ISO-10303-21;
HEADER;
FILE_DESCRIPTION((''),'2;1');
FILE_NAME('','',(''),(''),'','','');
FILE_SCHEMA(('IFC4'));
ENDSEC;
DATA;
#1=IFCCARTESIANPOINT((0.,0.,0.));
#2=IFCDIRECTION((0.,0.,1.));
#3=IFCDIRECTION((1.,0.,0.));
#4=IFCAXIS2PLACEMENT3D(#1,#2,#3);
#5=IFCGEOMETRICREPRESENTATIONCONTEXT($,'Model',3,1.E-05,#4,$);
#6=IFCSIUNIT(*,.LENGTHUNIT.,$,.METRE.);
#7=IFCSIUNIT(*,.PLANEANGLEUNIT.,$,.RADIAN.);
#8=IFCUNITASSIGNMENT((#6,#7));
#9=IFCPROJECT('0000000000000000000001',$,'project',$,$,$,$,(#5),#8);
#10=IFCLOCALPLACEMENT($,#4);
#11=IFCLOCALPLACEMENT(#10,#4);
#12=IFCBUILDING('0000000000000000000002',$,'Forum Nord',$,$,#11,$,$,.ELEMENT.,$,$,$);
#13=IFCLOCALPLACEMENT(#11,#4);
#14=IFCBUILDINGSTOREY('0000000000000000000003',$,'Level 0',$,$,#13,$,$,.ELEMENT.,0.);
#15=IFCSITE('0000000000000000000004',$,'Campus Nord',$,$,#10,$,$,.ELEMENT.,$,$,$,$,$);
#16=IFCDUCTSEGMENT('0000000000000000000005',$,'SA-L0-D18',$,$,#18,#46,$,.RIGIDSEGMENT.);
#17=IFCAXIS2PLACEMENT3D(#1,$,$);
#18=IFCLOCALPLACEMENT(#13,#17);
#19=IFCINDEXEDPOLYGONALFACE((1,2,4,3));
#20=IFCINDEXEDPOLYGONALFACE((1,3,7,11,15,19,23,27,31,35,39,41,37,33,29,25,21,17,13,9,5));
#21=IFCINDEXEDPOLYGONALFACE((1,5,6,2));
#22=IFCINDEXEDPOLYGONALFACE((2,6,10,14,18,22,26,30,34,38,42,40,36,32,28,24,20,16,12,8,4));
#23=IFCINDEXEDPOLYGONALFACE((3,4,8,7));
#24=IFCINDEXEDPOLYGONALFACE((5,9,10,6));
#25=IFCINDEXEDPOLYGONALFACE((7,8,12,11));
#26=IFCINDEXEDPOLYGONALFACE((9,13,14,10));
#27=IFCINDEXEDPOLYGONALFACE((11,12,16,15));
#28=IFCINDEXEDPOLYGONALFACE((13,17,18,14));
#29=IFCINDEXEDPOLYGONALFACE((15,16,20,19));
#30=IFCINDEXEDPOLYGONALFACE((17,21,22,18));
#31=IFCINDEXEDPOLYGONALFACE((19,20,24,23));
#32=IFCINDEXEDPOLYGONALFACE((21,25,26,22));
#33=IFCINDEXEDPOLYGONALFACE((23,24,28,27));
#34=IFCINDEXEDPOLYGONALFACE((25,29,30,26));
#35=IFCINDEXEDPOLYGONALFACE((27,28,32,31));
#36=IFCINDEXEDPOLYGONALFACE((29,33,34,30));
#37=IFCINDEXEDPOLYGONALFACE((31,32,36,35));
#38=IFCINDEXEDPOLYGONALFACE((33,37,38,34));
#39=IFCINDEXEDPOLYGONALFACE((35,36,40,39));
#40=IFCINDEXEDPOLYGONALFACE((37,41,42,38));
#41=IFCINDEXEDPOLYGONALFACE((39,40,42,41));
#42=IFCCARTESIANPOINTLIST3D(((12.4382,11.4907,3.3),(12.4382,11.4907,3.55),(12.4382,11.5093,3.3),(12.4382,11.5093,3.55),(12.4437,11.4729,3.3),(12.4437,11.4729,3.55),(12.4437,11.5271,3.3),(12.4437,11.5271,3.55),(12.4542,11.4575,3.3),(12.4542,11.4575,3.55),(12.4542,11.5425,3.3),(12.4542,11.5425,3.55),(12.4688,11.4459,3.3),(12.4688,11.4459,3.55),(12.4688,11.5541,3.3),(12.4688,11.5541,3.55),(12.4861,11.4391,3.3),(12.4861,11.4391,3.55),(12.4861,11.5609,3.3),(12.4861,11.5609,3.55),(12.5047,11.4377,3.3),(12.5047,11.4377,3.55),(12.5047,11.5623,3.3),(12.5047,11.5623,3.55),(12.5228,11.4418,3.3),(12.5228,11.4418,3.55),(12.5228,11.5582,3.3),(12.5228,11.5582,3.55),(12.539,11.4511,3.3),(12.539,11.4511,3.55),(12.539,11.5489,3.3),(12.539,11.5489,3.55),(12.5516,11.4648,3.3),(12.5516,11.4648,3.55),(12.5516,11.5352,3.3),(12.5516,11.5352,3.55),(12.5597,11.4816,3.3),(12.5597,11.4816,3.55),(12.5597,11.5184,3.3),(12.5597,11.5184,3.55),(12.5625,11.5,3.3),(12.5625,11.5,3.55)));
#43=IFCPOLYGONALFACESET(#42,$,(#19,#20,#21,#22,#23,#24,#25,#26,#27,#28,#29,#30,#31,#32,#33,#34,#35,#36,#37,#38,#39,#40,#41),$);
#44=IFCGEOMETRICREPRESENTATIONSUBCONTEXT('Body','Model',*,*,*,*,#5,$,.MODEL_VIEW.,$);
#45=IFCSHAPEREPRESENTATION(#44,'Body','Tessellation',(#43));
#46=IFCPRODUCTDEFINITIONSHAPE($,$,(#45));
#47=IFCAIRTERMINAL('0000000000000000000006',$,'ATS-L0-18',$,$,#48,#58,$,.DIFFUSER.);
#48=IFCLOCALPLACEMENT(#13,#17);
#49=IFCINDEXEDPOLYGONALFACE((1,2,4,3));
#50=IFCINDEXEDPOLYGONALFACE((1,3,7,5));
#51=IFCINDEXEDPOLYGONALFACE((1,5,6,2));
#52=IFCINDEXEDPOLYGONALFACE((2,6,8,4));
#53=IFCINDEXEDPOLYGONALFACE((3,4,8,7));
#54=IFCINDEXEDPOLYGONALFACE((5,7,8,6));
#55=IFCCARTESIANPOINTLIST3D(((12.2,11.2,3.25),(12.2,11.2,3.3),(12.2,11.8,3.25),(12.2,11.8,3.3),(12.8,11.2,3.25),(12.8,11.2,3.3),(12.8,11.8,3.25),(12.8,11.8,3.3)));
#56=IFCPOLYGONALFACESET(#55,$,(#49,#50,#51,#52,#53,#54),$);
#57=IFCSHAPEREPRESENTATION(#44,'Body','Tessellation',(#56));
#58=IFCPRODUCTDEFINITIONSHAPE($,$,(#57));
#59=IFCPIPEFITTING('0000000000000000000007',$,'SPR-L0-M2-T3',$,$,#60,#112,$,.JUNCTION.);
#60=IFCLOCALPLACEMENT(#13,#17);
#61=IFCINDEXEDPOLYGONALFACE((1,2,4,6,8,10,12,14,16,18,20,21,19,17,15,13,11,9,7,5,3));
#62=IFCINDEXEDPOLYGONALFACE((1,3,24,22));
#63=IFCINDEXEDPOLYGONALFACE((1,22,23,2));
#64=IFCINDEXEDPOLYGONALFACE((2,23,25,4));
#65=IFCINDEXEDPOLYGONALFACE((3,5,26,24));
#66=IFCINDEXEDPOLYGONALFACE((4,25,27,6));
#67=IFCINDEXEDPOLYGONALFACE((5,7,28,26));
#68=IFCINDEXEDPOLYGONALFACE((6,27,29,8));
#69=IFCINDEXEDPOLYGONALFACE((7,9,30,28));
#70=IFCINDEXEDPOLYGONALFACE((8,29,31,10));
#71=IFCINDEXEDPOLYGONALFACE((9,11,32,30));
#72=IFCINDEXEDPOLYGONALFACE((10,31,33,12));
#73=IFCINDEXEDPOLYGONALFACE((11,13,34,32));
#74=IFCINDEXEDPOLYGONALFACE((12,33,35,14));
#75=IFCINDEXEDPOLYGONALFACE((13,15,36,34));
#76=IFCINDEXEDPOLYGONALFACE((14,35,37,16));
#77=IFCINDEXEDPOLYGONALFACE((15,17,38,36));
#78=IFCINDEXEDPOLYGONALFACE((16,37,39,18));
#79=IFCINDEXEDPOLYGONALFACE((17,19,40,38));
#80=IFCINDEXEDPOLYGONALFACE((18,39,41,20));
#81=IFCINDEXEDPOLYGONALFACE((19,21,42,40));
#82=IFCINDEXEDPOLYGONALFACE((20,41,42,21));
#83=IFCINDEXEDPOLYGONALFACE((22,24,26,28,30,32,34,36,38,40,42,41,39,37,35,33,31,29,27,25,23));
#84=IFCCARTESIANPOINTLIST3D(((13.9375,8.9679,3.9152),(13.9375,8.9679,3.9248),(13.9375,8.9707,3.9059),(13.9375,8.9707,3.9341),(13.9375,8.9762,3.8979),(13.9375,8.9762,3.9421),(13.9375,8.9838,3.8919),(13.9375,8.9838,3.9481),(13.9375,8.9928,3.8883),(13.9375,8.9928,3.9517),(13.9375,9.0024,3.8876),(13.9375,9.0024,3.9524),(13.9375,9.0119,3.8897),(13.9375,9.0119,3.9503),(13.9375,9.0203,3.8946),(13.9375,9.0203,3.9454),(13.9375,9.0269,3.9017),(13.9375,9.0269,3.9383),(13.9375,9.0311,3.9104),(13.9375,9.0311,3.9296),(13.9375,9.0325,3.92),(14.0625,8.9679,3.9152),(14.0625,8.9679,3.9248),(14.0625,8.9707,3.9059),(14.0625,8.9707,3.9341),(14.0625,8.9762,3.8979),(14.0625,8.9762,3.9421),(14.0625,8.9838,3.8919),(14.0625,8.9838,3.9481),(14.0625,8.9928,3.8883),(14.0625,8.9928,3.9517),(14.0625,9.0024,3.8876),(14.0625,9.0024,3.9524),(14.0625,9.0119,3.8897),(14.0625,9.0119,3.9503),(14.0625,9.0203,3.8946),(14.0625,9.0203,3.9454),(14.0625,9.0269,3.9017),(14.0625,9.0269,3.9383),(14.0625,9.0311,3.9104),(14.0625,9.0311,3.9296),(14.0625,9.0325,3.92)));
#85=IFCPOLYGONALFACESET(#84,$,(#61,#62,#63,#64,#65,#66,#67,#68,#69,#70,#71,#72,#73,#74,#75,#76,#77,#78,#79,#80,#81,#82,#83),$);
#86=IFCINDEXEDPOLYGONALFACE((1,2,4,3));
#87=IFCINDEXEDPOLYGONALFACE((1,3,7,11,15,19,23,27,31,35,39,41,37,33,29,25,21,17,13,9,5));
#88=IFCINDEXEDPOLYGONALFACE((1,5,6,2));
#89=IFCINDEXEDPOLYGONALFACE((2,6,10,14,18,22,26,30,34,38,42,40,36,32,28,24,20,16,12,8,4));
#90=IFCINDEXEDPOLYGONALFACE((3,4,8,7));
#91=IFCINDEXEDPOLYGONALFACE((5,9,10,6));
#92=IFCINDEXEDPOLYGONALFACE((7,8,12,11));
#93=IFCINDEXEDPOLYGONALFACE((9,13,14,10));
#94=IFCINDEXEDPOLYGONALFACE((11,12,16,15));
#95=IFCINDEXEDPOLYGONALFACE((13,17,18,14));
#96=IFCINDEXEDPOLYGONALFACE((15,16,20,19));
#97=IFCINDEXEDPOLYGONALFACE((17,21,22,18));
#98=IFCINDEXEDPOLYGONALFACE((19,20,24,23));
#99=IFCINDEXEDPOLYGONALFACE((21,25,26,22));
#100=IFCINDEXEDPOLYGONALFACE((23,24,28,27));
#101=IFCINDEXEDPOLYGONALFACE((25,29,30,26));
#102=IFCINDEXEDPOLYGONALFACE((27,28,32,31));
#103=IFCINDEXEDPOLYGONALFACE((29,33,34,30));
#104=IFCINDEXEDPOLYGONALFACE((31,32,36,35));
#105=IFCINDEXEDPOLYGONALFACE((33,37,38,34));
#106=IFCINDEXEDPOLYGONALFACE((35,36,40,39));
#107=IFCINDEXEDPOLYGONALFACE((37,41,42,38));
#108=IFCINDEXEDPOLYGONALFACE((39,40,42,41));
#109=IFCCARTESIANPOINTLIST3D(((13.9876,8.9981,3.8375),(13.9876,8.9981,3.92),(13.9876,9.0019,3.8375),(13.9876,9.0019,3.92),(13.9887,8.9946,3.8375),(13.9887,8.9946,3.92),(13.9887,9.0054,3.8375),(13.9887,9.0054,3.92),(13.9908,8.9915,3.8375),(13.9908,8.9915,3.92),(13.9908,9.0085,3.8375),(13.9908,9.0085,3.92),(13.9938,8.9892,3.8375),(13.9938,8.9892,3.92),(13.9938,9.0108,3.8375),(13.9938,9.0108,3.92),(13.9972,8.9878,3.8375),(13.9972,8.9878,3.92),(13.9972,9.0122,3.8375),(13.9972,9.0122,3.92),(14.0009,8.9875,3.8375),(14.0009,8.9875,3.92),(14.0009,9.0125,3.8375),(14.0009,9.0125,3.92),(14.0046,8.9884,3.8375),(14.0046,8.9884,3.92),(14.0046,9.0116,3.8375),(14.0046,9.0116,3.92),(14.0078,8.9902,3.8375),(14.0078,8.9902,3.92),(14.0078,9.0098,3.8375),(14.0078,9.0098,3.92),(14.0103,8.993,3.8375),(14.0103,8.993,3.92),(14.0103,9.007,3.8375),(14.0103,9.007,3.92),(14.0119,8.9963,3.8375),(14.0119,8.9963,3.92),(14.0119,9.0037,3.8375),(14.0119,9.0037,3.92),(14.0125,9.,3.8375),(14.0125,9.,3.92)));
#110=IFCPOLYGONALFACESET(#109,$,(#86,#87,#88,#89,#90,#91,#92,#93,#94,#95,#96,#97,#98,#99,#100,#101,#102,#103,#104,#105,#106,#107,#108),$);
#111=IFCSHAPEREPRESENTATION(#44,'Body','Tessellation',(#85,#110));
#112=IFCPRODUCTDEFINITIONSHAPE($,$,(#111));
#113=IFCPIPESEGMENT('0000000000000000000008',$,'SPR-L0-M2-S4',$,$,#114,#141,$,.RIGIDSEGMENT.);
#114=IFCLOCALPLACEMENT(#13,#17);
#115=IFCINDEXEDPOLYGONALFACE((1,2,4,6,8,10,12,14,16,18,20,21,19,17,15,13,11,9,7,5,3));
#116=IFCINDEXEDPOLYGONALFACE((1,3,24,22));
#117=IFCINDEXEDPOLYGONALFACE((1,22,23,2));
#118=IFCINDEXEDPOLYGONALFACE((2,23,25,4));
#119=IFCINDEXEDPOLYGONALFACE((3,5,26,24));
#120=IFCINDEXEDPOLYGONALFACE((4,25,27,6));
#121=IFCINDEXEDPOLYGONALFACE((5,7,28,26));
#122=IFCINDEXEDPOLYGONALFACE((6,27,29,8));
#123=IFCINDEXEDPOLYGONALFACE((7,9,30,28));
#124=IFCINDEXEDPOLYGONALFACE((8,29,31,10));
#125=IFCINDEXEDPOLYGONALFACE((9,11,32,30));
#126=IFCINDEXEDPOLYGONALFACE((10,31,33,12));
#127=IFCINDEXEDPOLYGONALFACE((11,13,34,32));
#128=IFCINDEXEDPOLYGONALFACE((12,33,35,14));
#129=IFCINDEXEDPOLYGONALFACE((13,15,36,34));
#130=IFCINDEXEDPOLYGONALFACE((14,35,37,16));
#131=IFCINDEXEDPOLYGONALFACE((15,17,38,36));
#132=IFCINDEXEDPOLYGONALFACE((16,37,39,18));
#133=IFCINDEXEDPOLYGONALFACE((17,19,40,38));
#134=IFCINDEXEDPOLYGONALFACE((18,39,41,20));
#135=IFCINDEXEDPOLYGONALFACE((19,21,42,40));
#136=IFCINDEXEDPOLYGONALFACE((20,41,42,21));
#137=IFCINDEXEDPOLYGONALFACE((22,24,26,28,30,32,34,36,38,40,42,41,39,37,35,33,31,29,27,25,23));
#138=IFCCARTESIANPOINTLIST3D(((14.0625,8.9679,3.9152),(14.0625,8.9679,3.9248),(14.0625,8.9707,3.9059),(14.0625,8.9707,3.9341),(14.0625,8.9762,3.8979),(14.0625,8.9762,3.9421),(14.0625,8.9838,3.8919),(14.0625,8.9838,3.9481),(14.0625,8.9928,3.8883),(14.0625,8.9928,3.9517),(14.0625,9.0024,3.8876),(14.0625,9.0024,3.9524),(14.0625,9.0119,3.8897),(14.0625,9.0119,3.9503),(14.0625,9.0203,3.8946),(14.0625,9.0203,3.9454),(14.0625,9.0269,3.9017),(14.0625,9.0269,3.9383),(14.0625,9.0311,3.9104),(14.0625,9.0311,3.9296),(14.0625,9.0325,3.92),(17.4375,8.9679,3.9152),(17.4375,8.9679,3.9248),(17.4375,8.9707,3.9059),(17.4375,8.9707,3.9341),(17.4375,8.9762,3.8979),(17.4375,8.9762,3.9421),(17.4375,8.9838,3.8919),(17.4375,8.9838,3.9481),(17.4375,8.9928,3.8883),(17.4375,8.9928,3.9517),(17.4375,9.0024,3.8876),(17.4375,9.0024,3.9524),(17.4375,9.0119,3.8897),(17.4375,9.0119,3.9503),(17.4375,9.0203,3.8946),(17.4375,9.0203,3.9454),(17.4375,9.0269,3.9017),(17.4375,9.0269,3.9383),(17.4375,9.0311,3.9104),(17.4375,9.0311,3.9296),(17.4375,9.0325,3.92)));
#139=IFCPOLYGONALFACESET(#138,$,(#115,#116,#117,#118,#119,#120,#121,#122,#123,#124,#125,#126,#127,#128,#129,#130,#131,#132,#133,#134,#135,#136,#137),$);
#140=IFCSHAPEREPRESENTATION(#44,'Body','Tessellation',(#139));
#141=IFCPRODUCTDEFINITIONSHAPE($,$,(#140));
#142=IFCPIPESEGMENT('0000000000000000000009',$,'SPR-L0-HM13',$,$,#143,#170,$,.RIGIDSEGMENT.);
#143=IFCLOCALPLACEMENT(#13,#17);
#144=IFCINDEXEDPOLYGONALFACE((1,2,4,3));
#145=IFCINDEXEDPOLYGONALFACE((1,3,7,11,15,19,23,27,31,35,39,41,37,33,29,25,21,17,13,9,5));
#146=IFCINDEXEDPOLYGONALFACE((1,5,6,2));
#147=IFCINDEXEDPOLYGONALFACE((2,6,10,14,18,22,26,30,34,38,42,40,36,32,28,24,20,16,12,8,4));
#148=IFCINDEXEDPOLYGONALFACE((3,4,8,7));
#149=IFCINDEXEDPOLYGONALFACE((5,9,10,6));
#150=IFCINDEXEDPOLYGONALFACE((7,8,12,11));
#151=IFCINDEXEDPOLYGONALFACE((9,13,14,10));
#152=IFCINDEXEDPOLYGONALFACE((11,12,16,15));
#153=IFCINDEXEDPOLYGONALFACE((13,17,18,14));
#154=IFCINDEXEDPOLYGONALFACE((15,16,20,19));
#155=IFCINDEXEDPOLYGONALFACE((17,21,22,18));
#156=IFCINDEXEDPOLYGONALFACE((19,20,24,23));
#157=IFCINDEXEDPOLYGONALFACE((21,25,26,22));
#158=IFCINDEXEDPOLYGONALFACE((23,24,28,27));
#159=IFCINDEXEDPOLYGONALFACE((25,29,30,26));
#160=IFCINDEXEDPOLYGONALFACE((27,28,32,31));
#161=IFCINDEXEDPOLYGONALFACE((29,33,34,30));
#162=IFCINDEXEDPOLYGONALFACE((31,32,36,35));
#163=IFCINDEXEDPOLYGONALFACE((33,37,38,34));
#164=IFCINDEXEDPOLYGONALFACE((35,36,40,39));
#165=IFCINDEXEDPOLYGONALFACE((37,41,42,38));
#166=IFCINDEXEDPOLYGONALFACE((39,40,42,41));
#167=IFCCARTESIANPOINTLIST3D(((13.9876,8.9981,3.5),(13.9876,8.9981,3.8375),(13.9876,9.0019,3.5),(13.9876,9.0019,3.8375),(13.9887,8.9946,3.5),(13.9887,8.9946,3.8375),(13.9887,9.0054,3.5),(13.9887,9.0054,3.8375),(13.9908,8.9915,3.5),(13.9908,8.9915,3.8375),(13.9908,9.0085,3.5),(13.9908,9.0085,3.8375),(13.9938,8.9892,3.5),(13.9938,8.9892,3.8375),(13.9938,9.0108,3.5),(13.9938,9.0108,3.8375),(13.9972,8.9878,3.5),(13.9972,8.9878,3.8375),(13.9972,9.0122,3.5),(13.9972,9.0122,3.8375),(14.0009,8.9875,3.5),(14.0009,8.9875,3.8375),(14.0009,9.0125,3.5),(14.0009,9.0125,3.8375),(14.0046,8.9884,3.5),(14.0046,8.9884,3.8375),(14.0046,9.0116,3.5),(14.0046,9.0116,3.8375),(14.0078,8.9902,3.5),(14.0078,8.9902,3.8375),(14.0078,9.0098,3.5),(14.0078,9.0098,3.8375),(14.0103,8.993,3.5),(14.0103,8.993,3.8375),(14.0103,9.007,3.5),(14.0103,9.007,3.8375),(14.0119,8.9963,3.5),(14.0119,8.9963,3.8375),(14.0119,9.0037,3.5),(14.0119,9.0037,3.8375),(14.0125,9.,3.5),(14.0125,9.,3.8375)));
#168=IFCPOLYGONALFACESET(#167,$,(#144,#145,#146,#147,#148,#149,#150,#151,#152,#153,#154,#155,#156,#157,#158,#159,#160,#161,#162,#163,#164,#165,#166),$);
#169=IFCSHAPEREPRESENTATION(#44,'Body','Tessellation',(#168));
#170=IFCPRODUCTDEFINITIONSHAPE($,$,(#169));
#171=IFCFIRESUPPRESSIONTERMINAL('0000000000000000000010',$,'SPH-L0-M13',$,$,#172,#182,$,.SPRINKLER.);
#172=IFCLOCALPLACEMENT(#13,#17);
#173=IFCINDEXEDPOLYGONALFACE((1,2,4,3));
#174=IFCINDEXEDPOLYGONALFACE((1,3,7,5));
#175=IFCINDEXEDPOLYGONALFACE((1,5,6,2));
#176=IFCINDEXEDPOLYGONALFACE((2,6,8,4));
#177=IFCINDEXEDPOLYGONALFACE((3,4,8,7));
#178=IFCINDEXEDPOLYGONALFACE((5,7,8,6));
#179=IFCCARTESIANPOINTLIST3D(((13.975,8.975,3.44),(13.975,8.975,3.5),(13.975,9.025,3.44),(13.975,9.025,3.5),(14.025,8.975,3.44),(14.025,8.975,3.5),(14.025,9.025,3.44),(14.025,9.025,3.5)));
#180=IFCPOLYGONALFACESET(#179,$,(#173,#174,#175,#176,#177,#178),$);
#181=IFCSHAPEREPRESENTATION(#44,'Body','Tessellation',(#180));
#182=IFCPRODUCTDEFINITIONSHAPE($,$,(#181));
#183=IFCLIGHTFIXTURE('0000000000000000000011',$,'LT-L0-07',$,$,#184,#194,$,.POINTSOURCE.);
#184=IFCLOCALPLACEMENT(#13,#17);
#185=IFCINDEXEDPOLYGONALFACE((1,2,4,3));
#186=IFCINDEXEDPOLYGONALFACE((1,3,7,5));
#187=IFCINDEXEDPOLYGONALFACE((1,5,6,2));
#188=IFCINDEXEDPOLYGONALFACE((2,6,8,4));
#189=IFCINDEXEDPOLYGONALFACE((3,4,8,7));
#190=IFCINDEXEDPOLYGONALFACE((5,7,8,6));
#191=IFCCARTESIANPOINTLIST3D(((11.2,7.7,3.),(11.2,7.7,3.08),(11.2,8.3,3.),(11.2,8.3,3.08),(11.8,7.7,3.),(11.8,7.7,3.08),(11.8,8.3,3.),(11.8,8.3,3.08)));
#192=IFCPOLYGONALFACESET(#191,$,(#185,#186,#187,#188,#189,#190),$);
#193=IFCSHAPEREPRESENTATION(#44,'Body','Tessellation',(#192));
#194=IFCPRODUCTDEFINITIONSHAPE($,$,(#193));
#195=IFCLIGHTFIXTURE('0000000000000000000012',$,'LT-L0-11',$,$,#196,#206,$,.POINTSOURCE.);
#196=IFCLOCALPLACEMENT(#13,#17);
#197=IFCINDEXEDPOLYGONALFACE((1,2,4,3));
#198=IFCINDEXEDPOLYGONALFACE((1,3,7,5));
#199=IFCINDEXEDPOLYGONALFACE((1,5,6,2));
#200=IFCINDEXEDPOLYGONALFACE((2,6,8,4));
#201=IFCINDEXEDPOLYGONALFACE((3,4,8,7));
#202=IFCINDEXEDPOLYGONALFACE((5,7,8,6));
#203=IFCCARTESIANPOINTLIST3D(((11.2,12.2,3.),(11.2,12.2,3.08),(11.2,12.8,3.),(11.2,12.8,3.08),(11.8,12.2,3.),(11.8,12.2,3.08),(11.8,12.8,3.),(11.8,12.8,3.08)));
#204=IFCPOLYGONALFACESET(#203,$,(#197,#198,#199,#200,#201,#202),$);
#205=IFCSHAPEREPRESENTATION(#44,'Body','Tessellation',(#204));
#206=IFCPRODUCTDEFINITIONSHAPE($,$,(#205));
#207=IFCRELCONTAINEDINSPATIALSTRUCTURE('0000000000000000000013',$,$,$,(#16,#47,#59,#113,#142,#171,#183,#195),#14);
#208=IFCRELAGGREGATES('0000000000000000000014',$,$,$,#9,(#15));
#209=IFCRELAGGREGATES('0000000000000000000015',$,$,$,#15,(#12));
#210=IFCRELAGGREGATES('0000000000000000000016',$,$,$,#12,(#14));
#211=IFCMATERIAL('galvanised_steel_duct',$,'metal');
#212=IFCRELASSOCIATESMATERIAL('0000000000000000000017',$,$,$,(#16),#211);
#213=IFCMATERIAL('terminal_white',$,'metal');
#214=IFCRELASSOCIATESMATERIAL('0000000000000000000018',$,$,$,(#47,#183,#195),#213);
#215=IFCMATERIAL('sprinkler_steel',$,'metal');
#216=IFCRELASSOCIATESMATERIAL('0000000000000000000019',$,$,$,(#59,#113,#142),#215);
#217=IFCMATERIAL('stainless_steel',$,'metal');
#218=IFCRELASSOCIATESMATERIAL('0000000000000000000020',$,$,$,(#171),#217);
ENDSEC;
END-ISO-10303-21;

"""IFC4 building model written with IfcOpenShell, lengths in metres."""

from ifc_helpers import new_model, si_unit, frame, origin_with_axes, origin_2d_with_axis, place, context, subcontext, project, spatial, rectangle, circle, extrude, material, element, save


model = new_model("IFC4")

# Units and contexts
model_context = context("Model", 3, precision=1e-05, world=origin_with_axes())
body_context = subcontext(model_context, "Body", "Model", "MODEL_VIEW")
ifc_project = project(units=[si_unit("LENGTHUNIT", "METRE"), si_unit("PLANEANGLEUNIT", "RADIAN")], contexts=[model_context])

# Site, building, storey
site_placement = place(None, origin_with_axes())
site = spatial("IfcSite", under=ifc_project, at=site_placement, Name="Campus Nord", CompositionType="ELEMENT")
building_placement = place(site_placement, origin_with_axes())
building = spatial("IfcBuilding", under=site, at=building_placement, Name="Forum Nord", CompositionType="ELEMENT")
storey_placement = place(building_placement, origin_with_axes())
storey = spatial("IfcBuildingStorey", under=building, at=storey_placement, Name="Level 0", CompositionType="ELEMENT", Elevation=0.0)

# Shared definitions
ifc_material_1 = material(Name="galvanised_steel_duct", Category="metal")

# Shared definitions
ifc_material_2 = material(Name="terminal_white", Category="metal")

# Duct segment
duct_segment_1_placement = place(storey_placement, frame((12.5, 11.5, 3.55), z_axis=(0.0, 0.0, -1.0), x_axis=(1.0, 0.0, 0.0)))
element("IfcDuctSegment", 1, at=duct_segment_1_placement, inside=storey, material=ifc_material_1, Name="SA-L0-D18", PredefinedType="RIGIDSEGMENT", context=body_context, shape_type="SweptSolid", body=[
    extrude(circle(Radius=0.0625, at=origin_2d_with_axis()), origin_with_axes(), (0.0, 0.0, 1.0), 0.25),
])

# Air terminal
air_terminal_1_placement = place(storey_placement, frame((12.5, 11.5, 3.25), z_axis=(0.0, 0.0, 1.0), x_axis=(1.0, 0.0, 0.0)))
element("IfcAirTerminal", 2, at=air_terminal_1_placement, inside=storey, material=ifc_material_2, Name="ATS-L0-18", PredefinedType="DIFFUSER", context=body_context, shape_type="SweptSolid", body=[
    extrude(rectangle(XDim=0.6, YDim=0.6, at=origin_2d_with_axis()), origin_with_axes(), (0.0, 0.0, 1.0), 0.05),
])

# Pipe fitting
ifc_material_3 = material(Name="sprinkler_steel", Category="metal")
pipe_fitting_placement = place(storey_placement, frame((13.9375, 9.0, 3.92), z_axis=(1.0, 0.0, 0.0), x_axis=(0.0, 1.0, 0.0)))
element("IfcPipeFitting", 3, at=pipe_fitting_placement, inside=storey, material=ifc_material_3, Name="SPR-L0-M2-T3", PredefinedType="JUNCTION", context=body_context, shape_type="SweptSolid", body=[
    extrude(circle(Radius=0.0325, at=origin_2d_with_axis()), origin_with_axes(), (0.0, 0.0, 1.0), 0.125),
    extrude(circle(Radius=0.0125, at=origin_2d_with_axis()), frame((0.0, 0.0, 0.0625), z_axis=(0.0, -1.0, 0.0), x_axis=(0.0, 0.0, 1.0)), (0.0, 0.0, 1.0), 0.0825),
])

# Pipe segments
pipe_segment_1_placement = place(storey_placement, frame((14.0625, 9.0, 3.92), z_axis=(1.0, 0.0, 0.0), x_axis=(0.0, 1.0, 0.0)))
element("IfcPipeSegment", 4, at=pipe_segment_1_placement, inside=storey, material=ifc_material_3, Name="SPR-L0-M2-S4", PredefinedType="RIGIDSEGMENT", context=body_context, shape_type="SweptSolid", body=[
    extrude(circle(Radius=0.0325, at=origin_2d_with_axis()), origin_with_axes(), (0.0, 0.0, 1.0), 3.375),
])
pipe_segment_2_placement = place(storey_placement, frame((14.0, 9.0, 3.8375), z_axis=(0.0, 0.0, -1.0), x_axis=(1.0, 0.0, 0.0)))
element("IfcPipeSegment", 5, at=pipe_segment_2_placement, inside=storey, material=ifc_material_3, Name="SPR-L0-HM13", PredefinedType="RIGIDSEGMENT", context=body_context, shape_type="SweptSolid", body=[
    extrude(circle(Radius=0.0125, at=origin_2d_with_axis()), origin_with_axes(), (0.0, 0.0, 1.0), 0.3375),
])

# Fire suppression terminal
ifc_material_4 = material(Name="stainless_steel", Category="metal")
fire_suppression_terminal_placement = place(storey_placement, frame((14.0, 9.0, 3.44), z_axis=(0.0, 0.0, 1.0), x_axis=(1.0, 0.0, 0.0)))
element("IfcFireSuppressionTerminal", 6, at=fire_suppression_terminal_placement, inside=storey, material=ifc_material_4, Name="SPH-L0-M13", PredefinedType="SPRINKLER", context=body_context, shape_type="SweptSolid", body=[
    extrude(rectangle(XDim=0.05, YDim=0.05, at=origin_2d_with_axis()), origin_with_axes(), (0.0, 0.0, 1.0), 0.06),
])

# Light fixtures
for number, where, z_axis, x_axis, name in (
    (7, (11.5, 8.0, 3.0), (0.0, 0.0, 1.0), (1.0, 0.0, 0.0), "LT-L0-07"),
    (8, (11.5, 12.5, 3.0), (0.0, 0.0, 1.0), (1.0, 0.0, 0.0), "LT-L0-11"),
):
    element("IfcLightFixture", number, at=place(storey_placement, frame(where, z_axis=z_axis, x_axis=x_axis)), inside=storey, material=ifc_material_2, Name=name, PredefinedType="POINTSOURCE", context=body_context, shape_type="SweptSolid", body=[
        extrude(rectangle(XDim=0.6, YDim=0.6, at=origin_2d_with_axis()), origin_with_axes(), (0.0, 0.0, 1.0), 0.08),
    ])

save(model, "model.ifc")
